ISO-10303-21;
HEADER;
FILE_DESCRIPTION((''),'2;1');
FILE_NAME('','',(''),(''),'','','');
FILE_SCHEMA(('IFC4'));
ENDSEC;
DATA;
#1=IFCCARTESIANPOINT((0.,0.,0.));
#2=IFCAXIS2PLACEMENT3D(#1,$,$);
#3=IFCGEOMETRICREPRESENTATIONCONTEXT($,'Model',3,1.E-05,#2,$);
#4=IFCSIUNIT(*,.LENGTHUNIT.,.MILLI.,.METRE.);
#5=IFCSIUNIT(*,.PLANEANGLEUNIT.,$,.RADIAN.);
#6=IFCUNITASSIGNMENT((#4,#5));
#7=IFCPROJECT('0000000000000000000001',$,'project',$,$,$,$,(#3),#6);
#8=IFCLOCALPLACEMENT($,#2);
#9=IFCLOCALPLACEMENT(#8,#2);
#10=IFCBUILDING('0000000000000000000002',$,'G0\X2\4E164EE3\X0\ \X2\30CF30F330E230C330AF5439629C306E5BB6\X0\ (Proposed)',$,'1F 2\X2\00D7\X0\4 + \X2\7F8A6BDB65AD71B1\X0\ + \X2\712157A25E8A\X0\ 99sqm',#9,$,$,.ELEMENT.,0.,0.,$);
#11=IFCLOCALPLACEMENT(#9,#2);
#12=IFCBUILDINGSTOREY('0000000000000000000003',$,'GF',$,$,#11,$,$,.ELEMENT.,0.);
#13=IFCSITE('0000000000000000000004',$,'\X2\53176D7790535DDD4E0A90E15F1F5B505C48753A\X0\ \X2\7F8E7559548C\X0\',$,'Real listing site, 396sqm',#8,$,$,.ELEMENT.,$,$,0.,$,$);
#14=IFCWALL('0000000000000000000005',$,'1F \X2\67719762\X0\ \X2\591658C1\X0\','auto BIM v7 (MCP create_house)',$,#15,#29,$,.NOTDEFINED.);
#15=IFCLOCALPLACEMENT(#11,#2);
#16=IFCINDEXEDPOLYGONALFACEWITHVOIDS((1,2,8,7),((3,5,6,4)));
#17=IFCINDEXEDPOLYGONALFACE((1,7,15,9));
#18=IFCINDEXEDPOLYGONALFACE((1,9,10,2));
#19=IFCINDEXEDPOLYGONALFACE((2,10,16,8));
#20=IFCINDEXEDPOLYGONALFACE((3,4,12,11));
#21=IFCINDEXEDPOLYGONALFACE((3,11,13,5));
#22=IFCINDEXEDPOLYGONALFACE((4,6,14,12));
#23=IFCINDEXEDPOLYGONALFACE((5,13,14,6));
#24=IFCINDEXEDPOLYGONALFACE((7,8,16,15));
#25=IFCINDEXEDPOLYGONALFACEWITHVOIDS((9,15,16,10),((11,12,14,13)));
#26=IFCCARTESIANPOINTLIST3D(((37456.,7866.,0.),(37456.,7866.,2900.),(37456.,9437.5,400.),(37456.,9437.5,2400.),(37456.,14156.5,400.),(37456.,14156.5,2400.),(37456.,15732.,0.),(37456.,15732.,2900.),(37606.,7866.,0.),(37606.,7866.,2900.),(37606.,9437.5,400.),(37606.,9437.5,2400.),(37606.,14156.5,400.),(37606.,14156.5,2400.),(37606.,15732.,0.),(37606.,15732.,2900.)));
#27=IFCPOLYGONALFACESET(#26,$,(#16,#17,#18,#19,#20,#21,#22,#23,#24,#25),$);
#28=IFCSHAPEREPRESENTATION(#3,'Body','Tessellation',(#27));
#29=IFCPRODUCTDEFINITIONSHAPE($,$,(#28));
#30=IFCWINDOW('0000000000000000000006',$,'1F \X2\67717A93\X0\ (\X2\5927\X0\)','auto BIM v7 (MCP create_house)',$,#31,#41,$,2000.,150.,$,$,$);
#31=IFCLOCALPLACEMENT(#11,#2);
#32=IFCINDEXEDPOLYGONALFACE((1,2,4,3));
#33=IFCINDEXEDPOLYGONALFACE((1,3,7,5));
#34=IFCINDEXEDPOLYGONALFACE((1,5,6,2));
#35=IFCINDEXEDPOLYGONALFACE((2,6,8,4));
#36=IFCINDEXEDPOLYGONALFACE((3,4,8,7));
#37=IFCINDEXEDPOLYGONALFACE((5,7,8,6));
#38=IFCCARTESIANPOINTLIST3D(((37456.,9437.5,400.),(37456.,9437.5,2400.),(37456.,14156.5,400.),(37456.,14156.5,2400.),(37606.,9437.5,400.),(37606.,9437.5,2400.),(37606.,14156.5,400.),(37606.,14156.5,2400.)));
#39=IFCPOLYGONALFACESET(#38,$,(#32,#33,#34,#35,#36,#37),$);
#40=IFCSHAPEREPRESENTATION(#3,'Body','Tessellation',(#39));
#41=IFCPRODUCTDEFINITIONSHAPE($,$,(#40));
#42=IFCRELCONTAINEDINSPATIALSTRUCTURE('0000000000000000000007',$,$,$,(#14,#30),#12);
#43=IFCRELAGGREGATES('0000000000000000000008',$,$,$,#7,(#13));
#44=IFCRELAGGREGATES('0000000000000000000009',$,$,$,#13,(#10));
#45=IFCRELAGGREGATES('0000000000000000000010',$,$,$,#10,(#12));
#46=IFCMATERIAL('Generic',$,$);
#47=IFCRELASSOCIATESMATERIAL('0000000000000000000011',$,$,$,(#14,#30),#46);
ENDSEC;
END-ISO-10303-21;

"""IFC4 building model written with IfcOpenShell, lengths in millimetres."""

from ifc_helpers import new_model, si_unit, frame, frame_2d, origin, place, context, project, spatial, rectangle, extrude, material, element, fill, save


model = new_model("IFC4")

# Units and contexts
model_context = context("Model", 3, precision=1e-05, world=origin())
ifc_project = project(units=[si_unit("LENGTHUNIT", "METRE", prefix="MILLI"), si_unit("PLANEANGLEUNIT", "RADIAN")], contexts=[model_context])

# Site, building, storey
site_placement = place(None, origin())
site = spatial("IfcSite", under=ifc_project, at=site_placement, Name="北海道川上郡弟子屈町 美留和", ObjectType="Real listing site, 396sqm", CompositionType="ELEMENT", RefElevation=0.0)
building_placement = place(site_placement, origin())
building = spatial("IfcBuilding", under=site, at=building_placement, Name="G0世代 ハンモック吹抜の家 (Proposed)", ObjectType="1F 2×4 + 羊毛断熱 + 無垢床 99sqm", CompositionType="ELEMENT", ElevationOfRefHeight=0.0, ElevationOfTerrain=0.0)
storey_placement = place(building_placement, origin())
storey = spatial("IfcBuildingStorey", under=building, at=storey_placement, Name="GF", CompositionType="ELEMENT", Elevation=0.0)

# Shared definitions
ifc_material = material(Name="Generic")

# Wall, opening, window
wall_1_placement = place(storey_placement, frame((18728.0, 3933.0, 0.0)))
wall_1 = element("IfcWall", 1, at=wall_1_placement, inside=storey, material=ifc_material, Name="1F 東面 外壁", Description="auto BIM v7 (MCP create_house)", PredefinedType="NOTDEFINED", context=model_context, shape_type="SweptSolid", body=[
    extrude(rectangle(XDim=150.0, YDim=7866.0, at=frame_2d((75.0, 3933.0))), frame((18728.0, 3933.0, 0.0)), (0.0, 0.0, 1.0), 2900.0),
])
opening_1_placement = place(storey_placement, frame((18728.0, 4719.0, 200.0)))
opening_1 = element("IfcOpeningElement", 2, at=opening_1_placement, cuts=wall_1, PredefinedType="NOTDEFINED", context=model_context, shape_type="SweptSolid", body=[
    extrude(rectangle(XDim=150.0, YDim=4719.0, at=frame_2d((75.0, 2359.0))), frame((18728.0, 4719.0, 200.0)), (0.0, 0.0, 1.0), 2000.0),
])
window_1_placement = place(storey_placement, frame((18728.0, 4719.0, 200.0)))
window_1 = element("IfcWindow", 3, at=window_1_placement, inside=storey, material=ifc_material, Name="1F 東窓 (大)", Description="auto BIM v7 (MCP create_house)", OverallHeight=2000.0, OverallWidth=150.0, context=model_context, shape_type="SweptSolid", body=[
    extrude(rectangle(XDim=150.0, YDim=4719.0, at=frame_2d((75.0, 2359.0))), frame((18728.0, 4719.0, 200.0)), (0.0, 0.0, 1.0), 2000.0),
])
fill(opening_1, window_1)

save(model, "model.ifc")
